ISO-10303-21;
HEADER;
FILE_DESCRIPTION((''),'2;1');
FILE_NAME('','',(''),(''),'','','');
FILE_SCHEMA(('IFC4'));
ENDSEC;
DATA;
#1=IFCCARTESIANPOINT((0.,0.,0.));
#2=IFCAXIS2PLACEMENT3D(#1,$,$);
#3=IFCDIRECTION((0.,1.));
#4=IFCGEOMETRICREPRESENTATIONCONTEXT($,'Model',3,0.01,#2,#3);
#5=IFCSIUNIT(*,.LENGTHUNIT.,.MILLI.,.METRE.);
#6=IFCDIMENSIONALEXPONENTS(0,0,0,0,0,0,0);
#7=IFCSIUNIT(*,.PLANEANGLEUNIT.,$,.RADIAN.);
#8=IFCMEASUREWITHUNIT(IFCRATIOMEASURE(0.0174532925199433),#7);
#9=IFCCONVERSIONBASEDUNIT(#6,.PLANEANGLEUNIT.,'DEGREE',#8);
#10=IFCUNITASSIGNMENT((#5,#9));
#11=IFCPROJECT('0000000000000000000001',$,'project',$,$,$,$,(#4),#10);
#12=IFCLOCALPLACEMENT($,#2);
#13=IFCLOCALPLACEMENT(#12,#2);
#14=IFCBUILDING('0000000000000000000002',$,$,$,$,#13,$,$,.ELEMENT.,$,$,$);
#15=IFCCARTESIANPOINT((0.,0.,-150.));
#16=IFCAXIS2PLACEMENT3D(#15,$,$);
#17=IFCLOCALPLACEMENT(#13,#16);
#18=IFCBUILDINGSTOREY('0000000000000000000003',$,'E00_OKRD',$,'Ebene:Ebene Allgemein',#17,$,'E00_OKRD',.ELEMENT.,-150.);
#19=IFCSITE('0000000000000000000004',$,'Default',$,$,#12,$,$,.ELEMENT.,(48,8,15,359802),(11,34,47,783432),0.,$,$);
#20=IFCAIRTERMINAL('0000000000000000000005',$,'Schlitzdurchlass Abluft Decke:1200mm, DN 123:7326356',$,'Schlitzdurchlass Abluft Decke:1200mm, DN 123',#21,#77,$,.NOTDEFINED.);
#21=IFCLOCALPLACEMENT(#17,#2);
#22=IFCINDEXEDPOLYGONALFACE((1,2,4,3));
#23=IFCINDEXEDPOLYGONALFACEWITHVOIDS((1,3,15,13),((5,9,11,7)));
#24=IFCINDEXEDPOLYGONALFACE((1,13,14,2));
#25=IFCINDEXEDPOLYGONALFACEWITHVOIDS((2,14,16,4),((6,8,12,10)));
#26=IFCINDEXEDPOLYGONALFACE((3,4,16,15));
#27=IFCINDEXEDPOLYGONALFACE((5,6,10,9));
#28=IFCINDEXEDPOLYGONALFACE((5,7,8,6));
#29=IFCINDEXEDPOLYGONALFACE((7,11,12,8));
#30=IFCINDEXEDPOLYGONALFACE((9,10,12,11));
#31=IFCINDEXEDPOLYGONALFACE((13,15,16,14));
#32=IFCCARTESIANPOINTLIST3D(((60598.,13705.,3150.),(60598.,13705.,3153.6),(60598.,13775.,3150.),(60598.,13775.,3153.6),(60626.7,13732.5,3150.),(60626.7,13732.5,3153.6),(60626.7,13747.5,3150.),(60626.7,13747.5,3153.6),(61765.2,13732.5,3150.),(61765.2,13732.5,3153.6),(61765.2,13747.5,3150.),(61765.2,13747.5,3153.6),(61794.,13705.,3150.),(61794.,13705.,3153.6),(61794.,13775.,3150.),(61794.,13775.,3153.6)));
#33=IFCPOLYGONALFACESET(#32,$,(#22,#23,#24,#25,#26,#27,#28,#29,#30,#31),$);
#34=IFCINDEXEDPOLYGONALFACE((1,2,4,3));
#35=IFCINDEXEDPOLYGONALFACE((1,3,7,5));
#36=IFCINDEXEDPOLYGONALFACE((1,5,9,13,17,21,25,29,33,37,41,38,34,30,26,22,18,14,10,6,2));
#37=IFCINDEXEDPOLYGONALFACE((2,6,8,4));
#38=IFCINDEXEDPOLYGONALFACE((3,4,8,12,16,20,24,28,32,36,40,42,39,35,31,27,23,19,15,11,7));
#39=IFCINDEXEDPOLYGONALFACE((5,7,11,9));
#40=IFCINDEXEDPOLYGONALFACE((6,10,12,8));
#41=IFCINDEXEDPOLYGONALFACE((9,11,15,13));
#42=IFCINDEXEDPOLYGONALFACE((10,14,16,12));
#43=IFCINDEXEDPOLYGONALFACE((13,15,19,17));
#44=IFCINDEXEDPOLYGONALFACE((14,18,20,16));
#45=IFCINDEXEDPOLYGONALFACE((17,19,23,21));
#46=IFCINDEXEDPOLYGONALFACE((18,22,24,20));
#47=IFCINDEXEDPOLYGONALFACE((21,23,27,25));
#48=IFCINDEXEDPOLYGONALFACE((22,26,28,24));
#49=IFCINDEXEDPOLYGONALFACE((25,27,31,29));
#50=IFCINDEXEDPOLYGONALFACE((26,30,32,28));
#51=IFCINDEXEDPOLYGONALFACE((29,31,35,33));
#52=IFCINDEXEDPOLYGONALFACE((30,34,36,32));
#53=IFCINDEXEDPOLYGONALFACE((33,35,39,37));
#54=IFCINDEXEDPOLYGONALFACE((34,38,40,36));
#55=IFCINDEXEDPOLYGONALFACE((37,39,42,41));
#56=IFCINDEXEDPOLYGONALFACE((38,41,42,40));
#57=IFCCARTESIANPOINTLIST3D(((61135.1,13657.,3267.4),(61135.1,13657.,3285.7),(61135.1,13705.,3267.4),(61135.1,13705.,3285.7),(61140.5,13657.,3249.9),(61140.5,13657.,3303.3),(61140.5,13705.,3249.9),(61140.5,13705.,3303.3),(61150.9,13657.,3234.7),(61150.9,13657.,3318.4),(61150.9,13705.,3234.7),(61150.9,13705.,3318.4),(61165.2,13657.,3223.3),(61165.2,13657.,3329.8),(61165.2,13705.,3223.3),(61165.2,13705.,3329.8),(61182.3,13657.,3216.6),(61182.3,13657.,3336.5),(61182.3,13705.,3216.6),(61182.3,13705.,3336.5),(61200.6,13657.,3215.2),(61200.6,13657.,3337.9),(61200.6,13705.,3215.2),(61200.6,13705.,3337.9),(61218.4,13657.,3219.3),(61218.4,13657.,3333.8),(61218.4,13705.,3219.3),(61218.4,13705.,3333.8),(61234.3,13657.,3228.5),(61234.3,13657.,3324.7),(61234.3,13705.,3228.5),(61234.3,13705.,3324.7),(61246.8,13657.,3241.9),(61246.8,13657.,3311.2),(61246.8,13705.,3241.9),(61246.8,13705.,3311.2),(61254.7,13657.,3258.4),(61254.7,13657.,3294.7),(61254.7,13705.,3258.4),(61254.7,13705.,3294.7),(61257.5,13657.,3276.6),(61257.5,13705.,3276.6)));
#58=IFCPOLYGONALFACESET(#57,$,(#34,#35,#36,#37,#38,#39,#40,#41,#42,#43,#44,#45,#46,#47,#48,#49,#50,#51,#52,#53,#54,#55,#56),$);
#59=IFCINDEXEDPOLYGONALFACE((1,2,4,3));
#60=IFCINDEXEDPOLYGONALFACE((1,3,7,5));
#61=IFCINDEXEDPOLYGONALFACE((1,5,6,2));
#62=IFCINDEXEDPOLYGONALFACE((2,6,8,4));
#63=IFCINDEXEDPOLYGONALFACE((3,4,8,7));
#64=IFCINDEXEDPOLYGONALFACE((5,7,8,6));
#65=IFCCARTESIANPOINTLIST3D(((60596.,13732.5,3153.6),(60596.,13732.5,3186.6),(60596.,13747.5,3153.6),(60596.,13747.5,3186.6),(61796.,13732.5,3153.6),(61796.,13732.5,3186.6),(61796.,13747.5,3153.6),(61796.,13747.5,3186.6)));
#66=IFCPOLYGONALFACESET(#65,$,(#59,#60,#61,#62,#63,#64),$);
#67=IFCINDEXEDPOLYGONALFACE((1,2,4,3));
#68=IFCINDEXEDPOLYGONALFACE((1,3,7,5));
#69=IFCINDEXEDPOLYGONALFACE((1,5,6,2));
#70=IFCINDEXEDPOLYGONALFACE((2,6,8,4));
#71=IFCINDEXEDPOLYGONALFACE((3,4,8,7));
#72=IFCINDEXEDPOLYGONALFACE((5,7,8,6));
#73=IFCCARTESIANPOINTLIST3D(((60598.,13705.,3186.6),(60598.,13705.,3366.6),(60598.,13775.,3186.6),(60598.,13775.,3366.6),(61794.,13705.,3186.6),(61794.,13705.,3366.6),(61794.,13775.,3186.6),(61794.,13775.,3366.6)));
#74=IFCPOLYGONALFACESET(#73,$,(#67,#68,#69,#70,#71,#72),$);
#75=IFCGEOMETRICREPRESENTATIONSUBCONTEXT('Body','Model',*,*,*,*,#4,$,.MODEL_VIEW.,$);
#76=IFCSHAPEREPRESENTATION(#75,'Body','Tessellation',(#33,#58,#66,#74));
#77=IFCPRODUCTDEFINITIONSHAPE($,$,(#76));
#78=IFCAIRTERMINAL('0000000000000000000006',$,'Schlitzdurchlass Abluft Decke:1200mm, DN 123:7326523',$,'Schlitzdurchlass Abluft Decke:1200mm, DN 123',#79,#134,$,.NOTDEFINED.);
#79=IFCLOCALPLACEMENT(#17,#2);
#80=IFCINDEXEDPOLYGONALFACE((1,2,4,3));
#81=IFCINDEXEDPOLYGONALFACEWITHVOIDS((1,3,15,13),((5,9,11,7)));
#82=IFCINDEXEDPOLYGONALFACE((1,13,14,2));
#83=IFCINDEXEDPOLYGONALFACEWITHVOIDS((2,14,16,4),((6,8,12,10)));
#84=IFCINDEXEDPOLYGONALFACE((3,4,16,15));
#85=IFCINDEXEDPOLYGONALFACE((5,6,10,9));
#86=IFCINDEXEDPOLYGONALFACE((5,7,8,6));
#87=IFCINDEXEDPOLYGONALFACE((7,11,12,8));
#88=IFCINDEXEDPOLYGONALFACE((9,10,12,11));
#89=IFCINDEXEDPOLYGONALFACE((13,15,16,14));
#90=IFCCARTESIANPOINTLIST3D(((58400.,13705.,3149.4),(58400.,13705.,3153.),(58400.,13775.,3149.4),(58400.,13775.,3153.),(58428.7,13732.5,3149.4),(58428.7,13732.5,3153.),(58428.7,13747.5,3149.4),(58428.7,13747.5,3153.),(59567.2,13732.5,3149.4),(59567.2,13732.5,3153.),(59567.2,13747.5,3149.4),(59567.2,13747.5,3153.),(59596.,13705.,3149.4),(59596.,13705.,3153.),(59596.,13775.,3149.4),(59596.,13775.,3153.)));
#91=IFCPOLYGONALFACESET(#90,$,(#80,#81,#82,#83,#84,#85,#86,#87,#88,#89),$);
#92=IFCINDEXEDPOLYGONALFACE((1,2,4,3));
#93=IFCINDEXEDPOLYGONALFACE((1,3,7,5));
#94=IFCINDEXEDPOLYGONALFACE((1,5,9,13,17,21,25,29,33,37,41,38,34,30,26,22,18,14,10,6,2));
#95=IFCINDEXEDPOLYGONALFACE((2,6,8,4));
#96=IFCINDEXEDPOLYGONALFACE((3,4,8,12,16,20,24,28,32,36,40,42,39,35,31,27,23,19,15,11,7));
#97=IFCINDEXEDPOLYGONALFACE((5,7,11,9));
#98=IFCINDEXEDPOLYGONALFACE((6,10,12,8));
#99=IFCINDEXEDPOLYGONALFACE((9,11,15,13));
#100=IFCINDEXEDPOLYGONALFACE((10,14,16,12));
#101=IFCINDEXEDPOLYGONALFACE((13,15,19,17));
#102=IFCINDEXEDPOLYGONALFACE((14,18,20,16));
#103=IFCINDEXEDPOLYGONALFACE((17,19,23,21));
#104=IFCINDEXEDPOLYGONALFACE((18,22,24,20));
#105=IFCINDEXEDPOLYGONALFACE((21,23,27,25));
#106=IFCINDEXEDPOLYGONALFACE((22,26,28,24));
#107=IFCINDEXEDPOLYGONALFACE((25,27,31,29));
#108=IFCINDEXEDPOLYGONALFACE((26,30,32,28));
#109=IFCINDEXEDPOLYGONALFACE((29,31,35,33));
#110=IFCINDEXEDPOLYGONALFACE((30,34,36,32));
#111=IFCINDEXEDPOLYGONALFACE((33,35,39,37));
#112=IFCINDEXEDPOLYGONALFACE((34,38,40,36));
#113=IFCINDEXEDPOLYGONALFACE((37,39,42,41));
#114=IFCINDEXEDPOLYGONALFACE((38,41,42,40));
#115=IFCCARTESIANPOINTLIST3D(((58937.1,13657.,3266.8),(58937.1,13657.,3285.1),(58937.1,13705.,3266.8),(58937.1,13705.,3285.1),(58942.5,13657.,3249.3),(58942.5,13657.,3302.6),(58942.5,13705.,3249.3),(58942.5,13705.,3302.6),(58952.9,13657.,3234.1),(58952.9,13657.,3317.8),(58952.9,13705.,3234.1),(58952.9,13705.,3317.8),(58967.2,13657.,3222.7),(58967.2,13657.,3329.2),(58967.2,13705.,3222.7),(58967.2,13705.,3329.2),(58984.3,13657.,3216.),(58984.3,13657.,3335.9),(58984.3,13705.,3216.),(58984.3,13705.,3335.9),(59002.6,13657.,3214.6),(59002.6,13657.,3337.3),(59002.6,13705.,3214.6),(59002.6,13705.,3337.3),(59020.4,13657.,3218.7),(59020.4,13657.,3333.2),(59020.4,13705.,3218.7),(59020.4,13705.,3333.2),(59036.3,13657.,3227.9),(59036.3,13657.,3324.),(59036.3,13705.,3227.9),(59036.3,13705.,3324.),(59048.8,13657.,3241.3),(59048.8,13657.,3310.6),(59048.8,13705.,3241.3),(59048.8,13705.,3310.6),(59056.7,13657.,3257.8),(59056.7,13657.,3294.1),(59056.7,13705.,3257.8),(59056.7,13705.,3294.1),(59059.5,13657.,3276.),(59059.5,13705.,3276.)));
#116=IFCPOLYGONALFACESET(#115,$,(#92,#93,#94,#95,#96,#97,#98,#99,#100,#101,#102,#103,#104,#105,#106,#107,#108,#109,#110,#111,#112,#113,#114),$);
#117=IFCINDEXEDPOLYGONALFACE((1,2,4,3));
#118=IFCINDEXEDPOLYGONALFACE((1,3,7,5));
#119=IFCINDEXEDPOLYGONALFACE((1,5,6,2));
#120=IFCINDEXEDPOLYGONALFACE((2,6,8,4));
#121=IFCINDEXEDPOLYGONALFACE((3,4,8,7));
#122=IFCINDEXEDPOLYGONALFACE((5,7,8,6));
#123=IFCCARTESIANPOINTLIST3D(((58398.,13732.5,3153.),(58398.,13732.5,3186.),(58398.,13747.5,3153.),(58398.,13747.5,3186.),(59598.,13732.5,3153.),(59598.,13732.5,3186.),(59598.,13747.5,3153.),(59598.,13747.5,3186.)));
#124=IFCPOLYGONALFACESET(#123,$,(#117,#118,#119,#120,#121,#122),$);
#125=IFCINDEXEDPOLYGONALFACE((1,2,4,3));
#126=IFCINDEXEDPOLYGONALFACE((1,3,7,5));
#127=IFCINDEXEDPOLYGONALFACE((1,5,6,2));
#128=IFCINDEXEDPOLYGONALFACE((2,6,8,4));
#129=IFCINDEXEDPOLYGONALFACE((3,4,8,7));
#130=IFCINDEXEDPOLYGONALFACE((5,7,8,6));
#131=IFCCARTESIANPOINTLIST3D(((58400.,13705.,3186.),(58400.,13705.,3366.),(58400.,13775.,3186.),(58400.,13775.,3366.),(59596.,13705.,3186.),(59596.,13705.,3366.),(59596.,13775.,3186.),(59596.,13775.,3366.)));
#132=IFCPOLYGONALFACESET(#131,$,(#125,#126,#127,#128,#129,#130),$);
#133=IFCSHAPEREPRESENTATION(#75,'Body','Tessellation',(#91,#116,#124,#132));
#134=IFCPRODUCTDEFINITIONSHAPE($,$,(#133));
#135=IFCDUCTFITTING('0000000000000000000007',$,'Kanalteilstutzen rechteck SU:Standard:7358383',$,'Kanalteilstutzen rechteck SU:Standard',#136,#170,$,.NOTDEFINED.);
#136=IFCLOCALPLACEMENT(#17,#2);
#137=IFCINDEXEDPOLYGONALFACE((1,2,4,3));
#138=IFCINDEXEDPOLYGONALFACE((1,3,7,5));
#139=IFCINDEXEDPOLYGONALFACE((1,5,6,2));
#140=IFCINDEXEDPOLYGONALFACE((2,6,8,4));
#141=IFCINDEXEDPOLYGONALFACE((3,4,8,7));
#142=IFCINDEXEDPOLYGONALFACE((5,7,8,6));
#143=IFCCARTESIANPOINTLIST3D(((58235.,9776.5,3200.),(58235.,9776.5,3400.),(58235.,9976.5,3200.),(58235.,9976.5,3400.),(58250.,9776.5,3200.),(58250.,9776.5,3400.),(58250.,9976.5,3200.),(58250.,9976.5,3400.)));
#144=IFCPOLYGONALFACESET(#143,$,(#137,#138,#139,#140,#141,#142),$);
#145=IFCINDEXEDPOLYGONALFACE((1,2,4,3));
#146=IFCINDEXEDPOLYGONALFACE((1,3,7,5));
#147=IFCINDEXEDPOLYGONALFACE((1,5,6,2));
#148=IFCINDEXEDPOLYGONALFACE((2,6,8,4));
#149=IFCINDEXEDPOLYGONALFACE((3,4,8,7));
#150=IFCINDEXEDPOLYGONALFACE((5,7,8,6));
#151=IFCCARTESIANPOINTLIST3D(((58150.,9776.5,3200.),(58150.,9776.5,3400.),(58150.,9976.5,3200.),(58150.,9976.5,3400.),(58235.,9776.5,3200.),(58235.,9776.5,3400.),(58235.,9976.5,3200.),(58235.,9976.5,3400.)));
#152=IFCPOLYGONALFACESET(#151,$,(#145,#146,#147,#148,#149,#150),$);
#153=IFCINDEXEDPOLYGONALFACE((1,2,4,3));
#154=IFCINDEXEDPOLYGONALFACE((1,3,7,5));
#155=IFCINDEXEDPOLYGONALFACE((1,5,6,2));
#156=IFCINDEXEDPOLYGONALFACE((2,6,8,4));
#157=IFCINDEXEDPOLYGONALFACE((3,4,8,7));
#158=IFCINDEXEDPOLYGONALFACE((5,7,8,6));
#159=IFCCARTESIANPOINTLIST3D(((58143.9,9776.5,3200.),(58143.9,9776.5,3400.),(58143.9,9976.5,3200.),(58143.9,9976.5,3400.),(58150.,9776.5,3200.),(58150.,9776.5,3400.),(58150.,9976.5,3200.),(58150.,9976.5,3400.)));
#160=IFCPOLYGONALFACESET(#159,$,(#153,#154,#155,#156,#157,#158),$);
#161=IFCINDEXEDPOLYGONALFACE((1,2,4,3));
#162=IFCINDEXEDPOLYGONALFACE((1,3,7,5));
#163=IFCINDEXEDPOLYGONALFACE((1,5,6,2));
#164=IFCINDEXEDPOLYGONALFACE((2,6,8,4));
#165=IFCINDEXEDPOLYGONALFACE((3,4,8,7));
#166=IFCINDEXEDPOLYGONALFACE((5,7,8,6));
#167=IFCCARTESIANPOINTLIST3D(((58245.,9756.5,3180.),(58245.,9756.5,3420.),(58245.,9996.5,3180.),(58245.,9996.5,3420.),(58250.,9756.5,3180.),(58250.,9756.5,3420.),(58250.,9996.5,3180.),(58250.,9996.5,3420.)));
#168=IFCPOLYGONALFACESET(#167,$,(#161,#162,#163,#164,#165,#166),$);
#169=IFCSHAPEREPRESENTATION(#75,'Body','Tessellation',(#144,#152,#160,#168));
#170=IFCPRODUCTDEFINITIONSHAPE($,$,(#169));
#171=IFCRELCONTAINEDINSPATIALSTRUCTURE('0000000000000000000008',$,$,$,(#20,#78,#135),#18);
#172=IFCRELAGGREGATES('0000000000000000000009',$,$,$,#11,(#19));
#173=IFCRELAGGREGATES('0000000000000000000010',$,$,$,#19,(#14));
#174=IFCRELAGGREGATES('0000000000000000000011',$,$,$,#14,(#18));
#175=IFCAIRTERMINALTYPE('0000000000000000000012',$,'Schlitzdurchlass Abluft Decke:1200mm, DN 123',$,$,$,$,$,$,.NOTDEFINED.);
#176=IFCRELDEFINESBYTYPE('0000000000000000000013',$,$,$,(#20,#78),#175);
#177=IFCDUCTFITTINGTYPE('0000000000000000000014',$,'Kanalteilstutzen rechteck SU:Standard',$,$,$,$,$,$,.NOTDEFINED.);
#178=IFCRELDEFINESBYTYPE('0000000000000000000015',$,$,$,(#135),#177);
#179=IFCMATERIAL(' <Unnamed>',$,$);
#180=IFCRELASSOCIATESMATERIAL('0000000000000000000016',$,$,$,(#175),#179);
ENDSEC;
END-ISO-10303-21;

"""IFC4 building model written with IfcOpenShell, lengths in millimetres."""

from ifc_helpers import new_model, entity, si_unit, converted_unit, direction, frame, frame_2d, origin, origin_2d_with_axis, place, context, subcontext, project, spatial, polyline, rectangle, circle, outline, extrude, source, transform, mapped, material, type_object, type_shapes, element, save


model = new_model("IFC4")

# Units and contexts
model_context = context("Model", 3, precision=0.01, world=origin(), true_north=direction((0.0, 1.0)))
body_context = subcontext(model_context, "Body", "Model", "MODEL_VIEW")
ifc_project = project(units=[si_unit("LENGTHUNIT", "METRE", prefix="MILLI"), converted_unit("PLANEANGLEUNIT", "DEGREE", entity("IfcRatioMeasure", 0.0174532925199433), si_unit("PLANEANGLEUNIT", "RADIAN"), dimensions=[0, 0, 0, 0, 0, 0, 0])], contexts=[model_context])

# Site, building, storey
site_placement = place(None, origin())
site = spatial("IfcSite", under=ifc_project, at=site_placement, Name="Default", CompositionType="ELEMENT", RefLatitude=(48, 8, 15, 359802), RefLongitude=(11, 34, 47, 783432), RefElevation=0.0)
building_placement = place(site_placement, origin())
building = spatial("IfcBuilding", under=site, at=building_placement, CompositionType="ELEMENT")
storey_placement = place(building_placement, frame((0.0, 0.0, -150.0)))
storey = spatial("IfcBuildingStorey", under=building, at=storey_placement, Name="E00_OKRD", ObjectType="Ebene:Ebene Allgemein", LongName="E00_OKRD", CompositionType="ELEMENT", Elevation=-150.0)

# Air terminals
ifc_material_1 = material(Name=" <Unnamed>")
air_terminal_type_1 = type_object("IfcAirTerminalType", Name="Schlitzdurchlass Abluft Decke:1200mm, DN 123", PredefinedType="NOTDEFINED", material=ifc_material_1)
shared_shape_1 = source(origin(), body_context, "Body", "SweptSolid", [
    extrude(outline(polyline([(-598.0, -35.0), (598.0, -35.0), (598.0, 35.0), (-598.0, 35.0), (-598.0, -35.0)]), holes=[polyline([(-569.2, -7.5), (-569.2, 7.5), (569.2, 7.5), (569.2, -7.5), (-569.2, -7.5)])]), frame((0.0, 0.0, 0.0), z_axis=(0.0, 0.0, 1.0), x_axis=(-1.0, 0.0, 0.0)), (0.0, 0.0, 1.0), 3.6),
    extrude(circle(Radius=61.5, at=frame_2d((0.0, 0.0), x_axis=(1.0, 0.0))), frame((0.0, 35.0, 126.6), z_axis=(0.0, 1.0, 0.0), x_axis=(-1.0, 0.0, 0.0)), (0.0, 0.0, 1.0), 48.0),
    extrude(rectangle(XDim=1200.0, YDim=15.0, at=origin_2d_with_axis()), frame((0.0, 0.0, 3.6), z_axis=(0.0, 0.0, 1.0), x_axis=(-1.0, 0.0, 0.0)), (0.0, 0.0, 1.0), 33.0),
    extrude(rectangle(XDim=1196.0, YDim=70.0, at=origin_2d_with_axis()), frame((0.0, 0.0, 36.6), z_axis=(0.0, 0.0, 1.0), x_axis=(-1.0, 0.0, 0.0)), (0.0, 0.0, 1.0), 180.0),
])
type_shapes(air_terminal_type_1, [shared_shape_1])
for number, where, z_axis, x_axis, name in (
    (1, (61196.0, 13740.0, 3150.0), (0.0, 0.0, 1.0), (-1.0, 0.0, 0.0), "Schlitzdurchlass Abluft Decke:1200mm, DN 123:7326356"),
    (2, (58998.0, 13740.0, 3149.4), (0.0, 0.0, 1.0), (-1.0, 0.0, 0.0), "Schlitzdurchlass Abluft Decke:1200mm, DN 123:7326523"),
):
    element("IfcAirTerminal", number, at=place(storey_placement, frame(where, z_axis=z_axis, x_axis=x_axis)), inside=storey, type_object=air_terminal_type_1, Name=name, ObjectType="Schlitzdurchlass Abluft Decke:1200mm, DN 123", PredefinedType="NOTDEFINED", context=body_context, shape_type="MappedRepresentation", body=[
        mapped(shared_shape_1, transform((0.0, 0.0, 0.0), scale=1.0)),
    ])

# Duct fitting
duct_fitting_type_1 = type_object("IfcDuctFittingType", Name="Kanalteilstutzen rechteck SU:Standard", PredefinedType="NOTDEFINED")
shared_shape_2 = source(origin(), body_context, "Body", "SweptSolid", [
    extrude(rectangle(XDim=15.0, YDim=200.0, at=origin_2d_with_axis()), frame((92.5, 0.0, -100.0)), (0.0, 0.0, 1.0), 200.0),
    extrude(rectangle(XDim=85.0, YDim=200.0, at=frame_2d((0.0, 0.0), x_axis=(1.0, 0.0))), frame((42.5, 0.0, -100.0)), (0.0, 0.0, 1.0), 200.0),
    extrude(rectangle(XDim=6.1, YDim=200.0, at=frame_2d((0.0, 0.0), x_axis=(1.0, 0.0))), frame((-3.0, 0.0, -100.0)), (0.0, 0.0, 1.0), 200.0),
    extrude(rectangle(XDim=5.0, YDim=240.0, at=origin_2d_with_axis()), frame((97.5, 0.0, -120.0)), (0.0, 0.0, 1.0), 240.0),
])
type_shapes(duct_fitting_type_1, [shared_shape_2])
duct_fitting_1_placement = place(storey_placement, frame((58150.0, 9876.5, 3300.0), z_axis=(0.0, 0.0, -1.0), x_axis=(1.0, 0.0, 0.0)))
element("IfcDuctFitting", 3, at=duct_fitting_1_placement, inside=storey, type_object=duct_fitting_type_1, Name="Kanalteilstutzen rechteck SU:Standard:7358383", ObjectType="Kanalteilstutzen rechteck SU:Standard", PredefinedType="NOTDEFINED", context=body_context, shape_type="MappedRepresentation", body=[
    mapped(shared_shape_2, transform((0.0, 0.0, 0.0), scale=1.0)),
])

save(model, "model.ifc")
